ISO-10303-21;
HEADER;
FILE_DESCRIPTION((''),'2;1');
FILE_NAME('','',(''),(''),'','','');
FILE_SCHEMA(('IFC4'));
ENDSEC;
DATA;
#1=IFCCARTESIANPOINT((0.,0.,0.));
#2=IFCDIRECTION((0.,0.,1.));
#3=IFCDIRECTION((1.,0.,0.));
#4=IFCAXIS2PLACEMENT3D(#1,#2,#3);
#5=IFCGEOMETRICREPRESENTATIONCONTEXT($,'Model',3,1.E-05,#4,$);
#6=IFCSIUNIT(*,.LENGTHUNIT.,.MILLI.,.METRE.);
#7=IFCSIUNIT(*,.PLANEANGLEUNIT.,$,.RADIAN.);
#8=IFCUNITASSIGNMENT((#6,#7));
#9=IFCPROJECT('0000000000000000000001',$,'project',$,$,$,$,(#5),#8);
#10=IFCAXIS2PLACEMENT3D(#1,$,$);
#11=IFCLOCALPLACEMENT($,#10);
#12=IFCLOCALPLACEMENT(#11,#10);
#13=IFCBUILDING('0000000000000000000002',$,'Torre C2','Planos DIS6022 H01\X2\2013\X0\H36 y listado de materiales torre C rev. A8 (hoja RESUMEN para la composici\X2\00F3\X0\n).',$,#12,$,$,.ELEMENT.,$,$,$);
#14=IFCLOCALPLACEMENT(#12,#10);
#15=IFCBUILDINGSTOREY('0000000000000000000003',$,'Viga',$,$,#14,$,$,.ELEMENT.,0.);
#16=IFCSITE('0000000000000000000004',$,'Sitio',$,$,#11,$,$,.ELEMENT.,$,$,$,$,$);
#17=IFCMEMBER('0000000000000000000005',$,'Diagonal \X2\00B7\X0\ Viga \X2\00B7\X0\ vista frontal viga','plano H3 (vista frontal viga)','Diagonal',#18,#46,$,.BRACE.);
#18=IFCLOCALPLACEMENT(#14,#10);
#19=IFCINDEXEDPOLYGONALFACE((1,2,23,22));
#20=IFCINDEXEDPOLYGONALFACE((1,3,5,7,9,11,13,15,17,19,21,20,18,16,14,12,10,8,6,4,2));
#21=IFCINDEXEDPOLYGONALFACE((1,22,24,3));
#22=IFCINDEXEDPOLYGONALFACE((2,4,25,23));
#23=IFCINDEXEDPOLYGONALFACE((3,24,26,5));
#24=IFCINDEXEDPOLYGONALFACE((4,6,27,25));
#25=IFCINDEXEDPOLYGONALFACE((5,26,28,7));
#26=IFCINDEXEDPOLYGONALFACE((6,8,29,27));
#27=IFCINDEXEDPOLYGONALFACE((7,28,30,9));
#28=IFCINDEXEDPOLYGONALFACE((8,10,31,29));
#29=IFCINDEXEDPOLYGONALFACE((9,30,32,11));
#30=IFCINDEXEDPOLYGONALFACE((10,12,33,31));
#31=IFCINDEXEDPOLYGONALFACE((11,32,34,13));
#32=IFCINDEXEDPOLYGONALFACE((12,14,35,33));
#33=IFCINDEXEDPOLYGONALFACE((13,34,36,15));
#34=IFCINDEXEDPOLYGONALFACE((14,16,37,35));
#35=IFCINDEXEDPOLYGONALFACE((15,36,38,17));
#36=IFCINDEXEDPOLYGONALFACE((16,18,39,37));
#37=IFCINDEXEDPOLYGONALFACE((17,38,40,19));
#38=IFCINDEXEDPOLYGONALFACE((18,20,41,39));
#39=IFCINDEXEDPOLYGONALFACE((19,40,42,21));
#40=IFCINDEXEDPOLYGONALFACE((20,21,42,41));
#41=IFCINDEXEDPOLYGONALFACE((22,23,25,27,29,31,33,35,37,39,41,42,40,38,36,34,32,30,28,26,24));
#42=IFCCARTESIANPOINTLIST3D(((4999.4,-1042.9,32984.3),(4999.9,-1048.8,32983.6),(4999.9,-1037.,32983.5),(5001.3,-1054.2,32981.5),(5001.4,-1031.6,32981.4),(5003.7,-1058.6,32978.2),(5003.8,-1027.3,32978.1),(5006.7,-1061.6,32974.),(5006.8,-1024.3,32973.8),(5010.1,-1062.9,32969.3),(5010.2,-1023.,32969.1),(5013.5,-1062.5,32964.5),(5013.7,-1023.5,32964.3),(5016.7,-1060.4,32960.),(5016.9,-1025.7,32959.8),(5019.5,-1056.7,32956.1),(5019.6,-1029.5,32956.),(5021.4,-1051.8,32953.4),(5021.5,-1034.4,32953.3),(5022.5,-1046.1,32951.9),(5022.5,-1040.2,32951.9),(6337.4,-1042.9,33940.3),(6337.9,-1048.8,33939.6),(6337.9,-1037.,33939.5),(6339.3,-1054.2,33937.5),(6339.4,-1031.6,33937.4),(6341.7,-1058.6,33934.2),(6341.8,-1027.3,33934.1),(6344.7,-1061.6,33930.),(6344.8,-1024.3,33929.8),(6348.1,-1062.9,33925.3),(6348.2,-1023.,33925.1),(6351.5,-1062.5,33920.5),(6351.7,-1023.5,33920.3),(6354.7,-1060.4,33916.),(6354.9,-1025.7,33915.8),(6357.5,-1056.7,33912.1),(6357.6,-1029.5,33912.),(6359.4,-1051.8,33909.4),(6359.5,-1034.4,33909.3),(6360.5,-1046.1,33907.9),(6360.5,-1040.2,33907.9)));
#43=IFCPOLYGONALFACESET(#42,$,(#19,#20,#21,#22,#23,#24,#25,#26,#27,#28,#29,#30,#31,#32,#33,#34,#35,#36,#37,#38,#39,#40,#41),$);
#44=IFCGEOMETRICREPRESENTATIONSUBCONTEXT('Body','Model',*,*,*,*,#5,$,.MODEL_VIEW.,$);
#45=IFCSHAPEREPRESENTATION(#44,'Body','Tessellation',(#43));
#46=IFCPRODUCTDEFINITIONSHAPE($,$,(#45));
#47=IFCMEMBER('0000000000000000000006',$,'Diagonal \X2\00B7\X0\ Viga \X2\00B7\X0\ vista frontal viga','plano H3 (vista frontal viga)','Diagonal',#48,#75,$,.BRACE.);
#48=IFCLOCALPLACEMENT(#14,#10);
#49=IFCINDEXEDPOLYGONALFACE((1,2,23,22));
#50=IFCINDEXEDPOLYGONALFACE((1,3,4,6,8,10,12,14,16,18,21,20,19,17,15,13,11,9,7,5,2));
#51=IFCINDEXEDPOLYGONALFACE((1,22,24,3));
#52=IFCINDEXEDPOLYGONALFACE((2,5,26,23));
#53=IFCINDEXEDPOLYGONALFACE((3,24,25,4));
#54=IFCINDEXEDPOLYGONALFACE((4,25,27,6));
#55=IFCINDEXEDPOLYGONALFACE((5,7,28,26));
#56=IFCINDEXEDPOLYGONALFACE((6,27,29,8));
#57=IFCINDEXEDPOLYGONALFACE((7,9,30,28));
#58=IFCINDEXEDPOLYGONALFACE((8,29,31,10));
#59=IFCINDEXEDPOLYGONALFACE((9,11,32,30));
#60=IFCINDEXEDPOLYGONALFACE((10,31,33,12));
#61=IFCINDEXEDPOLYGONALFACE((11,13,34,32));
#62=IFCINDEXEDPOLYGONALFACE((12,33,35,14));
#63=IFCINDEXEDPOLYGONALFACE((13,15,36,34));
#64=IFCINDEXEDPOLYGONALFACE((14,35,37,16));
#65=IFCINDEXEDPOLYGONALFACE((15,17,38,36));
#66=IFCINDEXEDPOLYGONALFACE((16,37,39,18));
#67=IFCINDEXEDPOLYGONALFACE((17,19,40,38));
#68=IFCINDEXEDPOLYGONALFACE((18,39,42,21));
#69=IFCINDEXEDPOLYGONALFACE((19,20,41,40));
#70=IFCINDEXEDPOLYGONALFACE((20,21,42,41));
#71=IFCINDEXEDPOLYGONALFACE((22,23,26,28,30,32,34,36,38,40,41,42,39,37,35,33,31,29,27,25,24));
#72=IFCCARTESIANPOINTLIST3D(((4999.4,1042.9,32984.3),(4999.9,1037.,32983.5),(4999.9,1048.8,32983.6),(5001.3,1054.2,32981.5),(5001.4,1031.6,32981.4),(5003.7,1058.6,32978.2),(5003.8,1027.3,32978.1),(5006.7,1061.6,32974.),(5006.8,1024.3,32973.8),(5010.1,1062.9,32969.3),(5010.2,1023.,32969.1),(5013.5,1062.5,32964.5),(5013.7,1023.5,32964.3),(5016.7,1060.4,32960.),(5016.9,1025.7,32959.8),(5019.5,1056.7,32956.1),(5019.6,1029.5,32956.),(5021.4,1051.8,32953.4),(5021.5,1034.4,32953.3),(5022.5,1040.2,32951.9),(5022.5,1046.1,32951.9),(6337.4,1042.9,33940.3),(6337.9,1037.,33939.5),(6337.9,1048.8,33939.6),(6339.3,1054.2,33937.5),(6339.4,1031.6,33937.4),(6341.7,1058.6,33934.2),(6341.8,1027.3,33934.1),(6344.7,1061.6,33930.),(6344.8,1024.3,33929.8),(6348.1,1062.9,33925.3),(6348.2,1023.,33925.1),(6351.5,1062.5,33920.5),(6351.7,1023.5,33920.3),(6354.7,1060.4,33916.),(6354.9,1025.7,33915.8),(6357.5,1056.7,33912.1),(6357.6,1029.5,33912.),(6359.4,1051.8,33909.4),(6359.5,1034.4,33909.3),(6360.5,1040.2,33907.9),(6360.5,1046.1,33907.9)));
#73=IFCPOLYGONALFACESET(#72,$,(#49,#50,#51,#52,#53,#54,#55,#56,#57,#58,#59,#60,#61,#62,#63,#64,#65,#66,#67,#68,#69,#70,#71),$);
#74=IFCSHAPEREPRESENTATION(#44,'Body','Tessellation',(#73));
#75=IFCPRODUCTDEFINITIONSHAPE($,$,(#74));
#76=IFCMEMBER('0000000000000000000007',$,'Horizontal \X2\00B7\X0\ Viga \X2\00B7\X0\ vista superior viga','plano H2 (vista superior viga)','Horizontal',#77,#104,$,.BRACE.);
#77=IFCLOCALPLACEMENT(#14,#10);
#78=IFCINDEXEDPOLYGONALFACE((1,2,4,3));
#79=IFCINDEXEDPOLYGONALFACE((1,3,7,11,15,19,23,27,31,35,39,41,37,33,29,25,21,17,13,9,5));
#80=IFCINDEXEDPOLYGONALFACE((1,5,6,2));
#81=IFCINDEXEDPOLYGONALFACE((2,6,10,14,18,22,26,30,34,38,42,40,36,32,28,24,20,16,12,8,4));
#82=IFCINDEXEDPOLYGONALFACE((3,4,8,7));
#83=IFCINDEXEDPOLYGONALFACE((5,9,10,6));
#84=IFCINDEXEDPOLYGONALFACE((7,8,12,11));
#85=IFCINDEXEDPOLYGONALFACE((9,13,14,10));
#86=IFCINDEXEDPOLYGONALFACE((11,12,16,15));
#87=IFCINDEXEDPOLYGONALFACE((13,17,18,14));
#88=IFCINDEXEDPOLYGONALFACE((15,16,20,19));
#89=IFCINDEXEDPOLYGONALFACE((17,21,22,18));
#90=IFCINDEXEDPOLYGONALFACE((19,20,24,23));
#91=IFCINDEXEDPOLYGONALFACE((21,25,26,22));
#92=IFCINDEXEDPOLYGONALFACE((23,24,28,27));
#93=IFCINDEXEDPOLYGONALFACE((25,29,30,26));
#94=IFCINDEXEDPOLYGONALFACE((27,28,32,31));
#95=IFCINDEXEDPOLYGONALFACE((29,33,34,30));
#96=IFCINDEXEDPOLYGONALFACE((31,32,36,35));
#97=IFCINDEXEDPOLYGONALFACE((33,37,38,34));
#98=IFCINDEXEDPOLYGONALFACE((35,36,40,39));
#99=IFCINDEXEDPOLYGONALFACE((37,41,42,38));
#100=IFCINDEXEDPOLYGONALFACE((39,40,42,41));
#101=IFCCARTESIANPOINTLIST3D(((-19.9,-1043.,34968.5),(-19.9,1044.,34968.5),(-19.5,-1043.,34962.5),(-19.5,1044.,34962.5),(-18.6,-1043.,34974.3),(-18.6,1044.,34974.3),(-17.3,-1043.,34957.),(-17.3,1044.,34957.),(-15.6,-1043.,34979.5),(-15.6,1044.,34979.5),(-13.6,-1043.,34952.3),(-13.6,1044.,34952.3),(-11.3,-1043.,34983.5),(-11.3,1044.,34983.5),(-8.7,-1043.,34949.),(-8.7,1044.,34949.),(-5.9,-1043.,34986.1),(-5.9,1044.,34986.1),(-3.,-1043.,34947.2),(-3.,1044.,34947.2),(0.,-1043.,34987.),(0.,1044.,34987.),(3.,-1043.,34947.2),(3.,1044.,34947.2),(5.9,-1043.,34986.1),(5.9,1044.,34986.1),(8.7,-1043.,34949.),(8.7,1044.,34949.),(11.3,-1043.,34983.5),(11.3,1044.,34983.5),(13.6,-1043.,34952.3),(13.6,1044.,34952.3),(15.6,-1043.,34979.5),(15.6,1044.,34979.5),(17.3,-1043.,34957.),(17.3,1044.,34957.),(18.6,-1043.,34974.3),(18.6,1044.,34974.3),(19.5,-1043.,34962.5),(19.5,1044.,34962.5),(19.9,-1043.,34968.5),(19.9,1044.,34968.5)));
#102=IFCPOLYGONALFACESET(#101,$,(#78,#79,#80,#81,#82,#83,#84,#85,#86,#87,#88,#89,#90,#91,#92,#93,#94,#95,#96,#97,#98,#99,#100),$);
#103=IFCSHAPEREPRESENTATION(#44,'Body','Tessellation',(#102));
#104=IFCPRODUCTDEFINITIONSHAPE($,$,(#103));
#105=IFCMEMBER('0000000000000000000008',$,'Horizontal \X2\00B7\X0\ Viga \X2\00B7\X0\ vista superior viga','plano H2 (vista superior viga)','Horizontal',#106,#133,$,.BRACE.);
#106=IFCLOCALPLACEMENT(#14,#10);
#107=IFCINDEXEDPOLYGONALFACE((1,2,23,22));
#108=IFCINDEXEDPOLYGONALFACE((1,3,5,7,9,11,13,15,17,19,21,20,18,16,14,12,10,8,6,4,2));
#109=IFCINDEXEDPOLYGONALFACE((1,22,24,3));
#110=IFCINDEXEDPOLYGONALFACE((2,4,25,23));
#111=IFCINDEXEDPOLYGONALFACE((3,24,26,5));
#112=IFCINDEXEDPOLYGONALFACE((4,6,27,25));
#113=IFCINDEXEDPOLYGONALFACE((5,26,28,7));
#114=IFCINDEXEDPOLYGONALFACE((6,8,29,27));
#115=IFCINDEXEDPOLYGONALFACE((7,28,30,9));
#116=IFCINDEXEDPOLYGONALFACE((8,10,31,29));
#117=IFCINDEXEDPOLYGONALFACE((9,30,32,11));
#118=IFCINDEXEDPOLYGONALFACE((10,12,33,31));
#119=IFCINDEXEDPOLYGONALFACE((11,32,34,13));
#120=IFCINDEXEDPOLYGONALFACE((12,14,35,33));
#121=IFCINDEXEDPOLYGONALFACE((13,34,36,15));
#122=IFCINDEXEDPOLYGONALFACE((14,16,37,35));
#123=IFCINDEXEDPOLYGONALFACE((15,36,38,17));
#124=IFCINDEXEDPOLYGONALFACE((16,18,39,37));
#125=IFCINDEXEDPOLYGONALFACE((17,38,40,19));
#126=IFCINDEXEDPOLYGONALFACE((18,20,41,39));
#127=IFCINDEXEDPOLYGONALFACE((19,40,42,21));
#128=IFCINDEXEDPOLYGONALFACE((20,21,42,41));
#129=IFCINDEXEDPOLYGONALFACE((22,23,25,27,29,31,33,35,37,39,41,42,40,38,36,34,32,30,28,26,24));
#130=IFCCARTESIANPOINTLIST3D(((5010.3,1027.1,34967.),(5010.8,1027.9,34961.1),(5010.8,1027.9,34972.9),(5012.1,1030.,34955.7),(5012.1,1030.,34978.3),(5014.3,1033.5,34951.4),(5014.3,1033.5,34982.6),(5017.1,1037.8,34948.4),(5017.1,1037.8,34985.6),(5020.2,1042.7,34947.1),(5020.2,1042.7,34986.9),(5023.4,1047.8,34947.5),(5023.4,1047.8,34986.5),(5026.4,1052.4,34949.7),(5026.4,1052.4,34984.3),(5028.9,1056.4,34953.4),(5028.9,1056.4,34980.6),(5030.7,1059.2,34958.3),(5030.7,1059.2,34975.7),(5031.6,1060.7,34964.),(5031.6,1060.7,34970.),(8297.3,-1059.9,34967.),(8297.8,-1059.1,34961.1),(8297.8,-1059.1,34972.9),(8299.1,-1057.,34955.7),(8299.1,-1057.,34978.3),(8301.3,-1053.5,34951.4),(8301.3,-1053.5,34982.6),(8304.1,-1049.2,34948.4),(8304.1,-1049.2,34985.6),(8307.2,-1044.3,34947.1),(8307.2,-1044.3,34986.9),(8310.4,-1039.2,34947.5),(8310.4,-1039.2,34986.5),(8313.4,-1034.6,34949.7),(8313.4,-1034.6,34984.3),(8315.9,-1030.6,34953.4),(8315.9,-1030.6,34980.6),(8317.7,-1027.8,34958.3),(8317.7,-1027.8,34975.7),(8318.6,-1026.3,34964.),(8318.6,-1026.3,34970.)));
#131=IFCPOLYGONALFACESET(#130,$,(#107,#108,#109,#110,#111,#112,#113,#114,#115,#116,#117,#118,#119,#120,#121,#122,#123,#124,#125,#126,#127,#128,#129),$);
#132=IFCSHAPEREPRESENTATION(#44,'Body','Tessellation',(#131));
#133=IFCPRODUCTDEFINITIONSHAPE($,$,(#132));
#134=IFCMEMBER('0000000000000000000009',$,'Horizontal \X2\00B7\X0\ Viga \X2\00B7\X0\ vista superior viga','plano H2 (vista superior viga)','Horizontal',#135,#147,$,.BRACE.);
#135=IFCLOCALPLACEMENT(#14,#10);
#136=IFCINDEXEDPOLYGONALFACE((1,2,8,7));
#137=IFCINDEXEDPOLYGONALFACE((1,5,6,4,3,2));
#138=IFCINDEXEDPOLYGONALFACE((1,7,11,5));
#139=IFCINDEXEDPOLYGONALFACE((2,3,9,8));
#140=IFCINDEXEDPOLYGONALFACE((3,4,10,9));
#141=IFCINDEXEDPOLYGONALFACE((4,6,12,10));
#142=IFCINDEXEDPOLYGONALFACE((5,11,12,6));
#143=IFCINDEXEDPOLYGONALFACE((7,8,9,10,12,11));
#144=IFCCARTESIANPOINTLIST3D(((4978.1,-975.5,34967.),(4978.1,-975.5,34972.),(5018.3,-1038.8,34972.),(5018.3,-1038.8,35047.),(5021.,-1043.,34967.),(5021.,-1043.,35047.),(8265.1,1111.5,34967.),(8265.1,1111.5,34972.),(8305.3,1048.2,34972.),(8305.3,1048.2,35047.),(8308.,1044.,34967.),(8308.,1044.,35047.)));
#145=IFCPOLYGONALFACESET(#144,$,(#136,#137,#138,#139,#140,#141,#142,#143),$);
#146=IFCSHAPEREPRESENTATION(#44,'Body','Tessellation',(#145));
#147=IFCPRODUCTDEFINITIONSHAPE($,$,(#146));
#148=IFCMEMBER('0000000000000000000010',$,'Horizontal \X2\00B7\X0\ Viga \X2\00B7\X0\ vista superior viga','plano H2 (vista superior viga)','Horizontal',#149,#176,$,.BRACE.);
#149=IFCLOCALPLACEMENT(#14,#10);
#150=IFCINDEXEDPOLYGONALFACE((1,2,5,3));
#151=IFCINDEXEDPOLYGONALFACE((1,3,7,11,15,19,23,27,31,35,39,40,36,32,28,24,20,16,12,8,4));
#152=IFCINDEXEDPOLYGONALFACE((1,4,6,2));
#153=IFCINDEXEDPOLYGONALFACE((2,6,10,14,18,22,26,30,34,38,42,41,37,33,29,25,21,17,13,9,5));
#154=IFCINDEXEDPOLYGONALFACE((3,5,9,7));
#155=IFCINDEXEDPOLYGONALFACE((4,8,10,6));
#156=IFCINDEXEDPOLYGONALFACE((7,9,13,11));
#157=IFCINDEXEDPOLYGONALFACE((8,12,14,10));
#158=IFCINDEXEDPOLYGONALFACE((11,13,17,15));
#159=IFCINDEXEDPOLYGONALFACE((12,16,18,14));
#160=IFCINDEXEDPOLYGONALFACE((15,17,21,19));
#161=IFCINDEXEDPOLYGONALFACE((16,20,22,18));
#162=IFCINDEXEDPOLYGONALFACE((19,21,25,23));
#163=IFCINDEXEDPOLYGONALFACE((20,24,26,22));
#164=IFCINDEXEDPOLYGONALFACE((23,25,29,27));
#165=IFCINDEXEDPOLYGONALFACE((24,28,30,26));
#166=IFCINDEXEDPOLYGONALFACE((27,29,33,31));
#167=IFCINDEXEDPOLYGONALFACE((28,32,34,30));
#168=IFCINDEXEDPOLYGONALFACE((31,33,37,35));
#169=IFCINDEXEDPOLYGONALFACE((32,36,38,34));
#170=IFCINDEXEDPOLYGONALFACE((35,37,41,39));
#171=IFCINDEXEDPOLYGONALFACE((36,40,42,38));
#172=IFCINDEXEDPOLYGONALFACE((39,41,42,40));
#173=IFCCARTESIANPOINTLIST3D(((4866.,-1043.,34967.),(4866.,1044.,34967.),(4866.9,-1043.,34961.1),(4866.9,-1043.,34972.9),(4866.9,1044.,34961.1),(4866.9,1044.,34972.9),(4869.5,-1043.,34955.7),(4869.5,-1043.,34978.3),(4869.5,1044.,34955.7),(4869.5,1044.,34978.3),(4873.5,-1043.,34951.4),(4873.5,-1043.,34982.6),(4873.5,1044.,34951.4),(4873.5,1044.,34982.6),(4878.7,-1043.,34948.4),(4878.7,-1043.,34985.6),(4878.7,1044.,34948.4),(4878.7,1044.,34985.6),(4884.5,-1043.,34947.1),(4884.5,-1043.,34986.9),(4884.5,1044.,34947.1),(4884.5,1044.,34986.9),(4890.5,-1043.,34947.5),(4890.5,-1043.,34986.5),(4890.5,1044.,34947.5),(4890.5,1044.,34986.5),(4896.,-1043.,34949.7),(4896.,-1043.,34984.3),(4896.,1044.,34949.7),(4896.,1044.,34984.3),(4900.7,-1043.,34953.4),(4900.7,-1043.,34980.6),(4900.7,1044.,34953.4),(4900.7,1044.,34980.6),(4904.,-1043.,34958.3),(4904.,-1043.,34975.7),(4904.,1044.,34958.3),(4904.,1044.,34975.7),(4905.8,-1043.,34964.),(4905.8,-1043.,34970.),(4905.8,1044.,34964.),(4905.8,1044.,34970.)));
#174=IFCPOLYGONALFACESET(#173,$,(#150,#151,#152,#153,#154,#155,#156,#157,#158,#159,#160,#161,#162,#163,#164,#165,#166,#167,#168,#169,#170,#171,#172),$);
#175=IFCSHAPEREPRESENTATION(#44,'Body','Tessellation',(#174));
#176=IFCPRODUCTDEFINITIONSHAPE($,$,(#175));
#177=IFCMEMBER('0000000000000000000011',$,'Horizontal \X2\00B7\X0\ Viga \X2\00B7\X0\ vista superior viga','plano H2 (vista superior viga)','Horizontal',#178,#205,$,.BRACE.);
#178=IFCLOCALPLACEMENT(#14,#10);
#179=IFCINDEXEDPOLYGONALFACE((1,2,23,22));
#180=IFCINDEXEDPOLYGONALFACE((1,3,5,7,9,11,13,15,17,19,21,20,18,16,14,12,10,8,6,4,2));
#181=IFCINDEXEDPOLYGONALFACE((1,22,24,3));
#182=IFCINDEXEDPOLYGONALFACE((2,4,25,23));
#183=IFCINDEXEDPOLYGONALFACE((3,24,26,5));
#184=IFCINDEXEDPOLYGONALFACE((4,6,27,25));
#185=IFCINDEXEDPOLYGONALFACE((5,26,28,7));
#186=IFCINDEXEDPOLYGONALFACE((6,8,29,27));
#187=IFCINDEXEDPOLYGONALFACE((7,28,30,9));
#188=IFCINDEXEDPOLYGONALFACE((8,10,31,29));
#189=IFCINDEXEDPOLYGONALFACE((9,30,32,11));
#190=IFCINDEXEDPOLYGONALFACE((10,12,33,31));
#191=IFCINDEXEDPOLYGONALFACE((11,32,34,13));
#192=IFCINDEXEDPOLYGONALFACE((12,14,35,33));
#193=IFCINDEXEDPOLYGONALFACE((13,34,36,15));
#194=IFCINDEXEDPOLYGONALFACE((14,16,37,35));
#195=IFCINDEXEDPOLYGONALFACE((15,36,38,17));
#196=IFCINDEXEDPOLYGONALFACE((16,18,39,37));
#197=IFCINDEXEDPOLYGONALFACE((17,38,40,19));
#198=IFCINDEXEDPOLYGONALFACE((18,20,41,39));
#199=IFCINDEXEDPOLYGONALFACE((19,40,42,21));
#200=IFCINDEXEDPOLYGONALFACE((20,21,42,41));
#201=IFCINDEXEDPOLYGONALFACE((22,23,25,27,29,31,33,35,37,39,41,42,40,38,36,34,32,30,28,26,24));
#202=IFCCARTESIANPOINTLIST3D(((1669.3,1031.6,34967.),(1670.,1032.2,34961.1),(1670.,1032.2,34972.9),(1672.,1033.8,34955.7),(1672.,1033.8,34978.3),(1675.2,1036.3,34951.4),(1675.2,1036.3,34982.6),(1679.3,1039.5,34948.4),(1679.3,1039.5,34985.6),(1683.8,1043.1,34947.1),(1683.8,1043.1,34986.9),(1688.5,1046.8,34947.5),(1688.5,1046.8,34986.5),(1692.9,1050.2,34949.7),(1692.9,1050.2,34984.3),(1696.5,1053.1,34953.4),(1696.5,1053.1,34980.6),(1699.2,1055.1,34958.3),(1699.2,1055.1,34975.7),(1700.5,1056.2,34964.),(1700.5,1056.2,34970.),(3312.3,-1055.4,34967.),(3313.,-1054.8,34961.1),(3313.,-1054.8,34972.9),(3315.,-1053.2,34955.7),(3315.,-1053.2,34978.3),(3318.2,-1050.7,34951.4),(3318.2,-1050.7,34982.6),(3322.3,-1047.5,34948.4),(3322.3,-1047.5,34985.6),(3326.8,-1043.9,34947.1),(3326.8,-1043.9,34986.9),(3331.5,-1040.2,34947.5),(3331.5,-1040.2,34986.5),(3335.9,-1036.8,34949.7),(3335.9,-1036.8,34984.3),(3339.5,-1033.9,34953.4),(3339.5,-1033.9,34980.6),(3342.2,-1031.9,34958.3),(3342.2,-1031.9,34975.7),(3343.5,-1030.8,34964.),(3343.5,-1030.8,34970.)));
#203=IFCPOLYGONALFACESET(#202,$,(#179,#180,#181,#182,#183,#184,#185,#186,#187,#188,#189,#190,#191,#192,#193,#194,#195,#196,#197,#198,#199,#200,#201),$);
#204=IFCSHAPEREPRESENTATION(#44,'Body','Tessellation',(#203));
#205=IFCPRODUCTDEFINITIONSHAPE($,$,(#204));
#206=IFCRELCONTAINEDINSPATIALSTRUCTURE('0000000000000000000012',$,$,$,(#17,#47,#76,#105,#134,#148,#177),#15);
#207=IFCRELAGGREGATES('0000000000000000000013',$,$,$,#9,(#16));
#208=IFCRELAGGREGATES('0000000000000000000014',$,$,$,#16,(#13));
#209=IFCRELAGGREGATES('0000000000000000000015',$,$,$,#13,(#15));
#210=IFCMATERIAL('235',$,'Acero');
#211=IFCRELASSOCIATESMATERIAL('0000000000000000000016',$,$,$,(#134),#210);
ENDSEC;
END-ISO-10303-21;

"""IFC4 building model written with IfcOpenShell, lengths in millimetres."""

from ifc_helpers import new_model, si_unit, frame, frame_2d, origin, origin_with_axes, place, context, subcontext, project, spatial, circle, l_section, extrude, material, element, save


model = new_model("IFC4")

# Units and contexts
model_context = context("Model", 3, precision=1e-05, world=origin_with_axes())
body_context = subcontext(model_context, "Body", "Model", "MODEL_VIEW")
ifc_project = project(units=[si_unit("LENGTHUNIT", "METRE", prefix="MILLI"), si_unit("PLANEANGLEUNIT", "RADIAN")], contexts=[model_context])

# Site, building, storey
site_placement = place(None, origin())
site = spatial("IfcSite", under=ifc_project, at=site_placement, Name="Sitio", CompositionType="ELEMENT")
building_placement = place(site_placement, origin())
building = spatial("IfcBuilding", under=site, at=building_placement, Name="Torre C2", Description="Planos DIS6022 H01–H36 y listado de materiales torre C rev. A8 (hoja RESUMEN para la composición).", CompositionType="ELEMENT")
storey_placement = place(building_placement, origin())
storey = spatial("IfcBuildingStorey", under=building, at=storey_placement, Name="Viga", CompositionType="ELEMENT", Elevation=0.0)

# Members
for number, where, z_axis, x_axis, name in (
    (1, (5011.0, -1043.0, 32968.0), (0.813651, 0.0, 0.581353), (-0.554357, 0.301193, 0.775868), "Diagonal · Viga · vista frontal viga"),
    (2, (5011.0, 1043.0, 32968.0), (0.813651, 0.0, 0.581353), (-0.554357, -0.301193, 0.775868), "Diagonal · Viga · vista frontal viga"),
):
    element("IfcMember", number, at=place(storey_placement, frame(where, z_axis=z_axis, x_axis=x_axis)), inside=storey, Name=name, Description="plano H3 (vista frontal viga)", ObjectType="Diagonal", PredefinedType="BRACE", context=body_context, shape_type="SweptSolid", body=[
        extrude(circle(Radius=20.0), None, (0.0, 0.0, 1.0), 1644.4),
    ])
member_1_placement = place(storey_placement, frame((0.0, 1044.0, 34967.0), z_axis=(0.0, -1.0, 0.0), x_axis=(0.0, 0.0, 1.0)))
element("IfcMember", 3, at=member_1_placement, inside=storey, Name="Horizontal · Viga · vista superior viga", Description="plano H2 (vista superior viga)", ObjectType="Horizontal", PredefinedType="BRACE", context=body_context, shape_type="SweptSolid", body=[
    extrude(circle(Radius=20.0), None, (0.0, 0.0, 1.0), 2087.0),
])
member_2_placement = place(storey_placement, frame((5021.0, 1044.0, 34967.0), z_axis=(0.844211, -0.536011, 0.0), x_axis=(-0.536011, -0.844211, 0.0)))
element("IfcMember", 4, at=member_2_placement, inside=storey, Name="Horizontal · Viga · vista superior viga", Description="plano H2 (vista superior viga)", ObjectType="Horizontal", PredefinedType="BRACE", context=body_context, shape_type="SweptSolid", body=[
    extrude(circle(Radius=20.0), None, (0.0, 0.0, 1.0), 3893.6),
])
ifc_material_1 = material(Name="235", Category="Acero")
member_3_placement = place(storey_placement, frame((5021.0, -1043.0, 34967.0), z_axis=(0.844211, 0.536011, 0.0), x_axis=(-0.536011, 0.844211, 0.0)))
element("IfcMember", 5, at=member_3_placement, inside=storey, material=ifc_material_1, Name="Horizontal · Viga · vista superior viga", Description="plano H2 (vista superior viga)", ObjectType="Horizontal", PredefinedType="BRACE", context=body_context, shape_type="SweptSolid", body=[
    extrude(l_section(Depth=80.0, Width=80.0, Thickness=5.0, at=frame_2d((40.0, 40.0))), None, (0.0, 0.0, 1.0), 3893.6),
])
member_4_placement = place(storey_placement, frame((4886.0, 1044.0, 34967.0), z_axis=(0.0, -1.0, 0.0), x_axis=(-1.0, 0.0, 0.0)))
element("IfcMember", 6, at=member_4_placement, inside=storey, Name="Horizontal · Viga · vista superior viga", Description="plano H2 (vista superior viga)", ObjectType="Horizontal", PredefinedType="BRACE", context=body_context, shape_type="SweptSolid", body=[
    extrude(circle(Radius=20.0), None, (0.0, 0.0, 1.0), 2087.0),
])
member_5_placement = place(storey_placement, frame((1685.0, 1044.0, 34967.0), z_axis=(0.618569, -0.78573, 0.0), x_axis=(-0.78573, -0.618569, 0.0)))
element("IfcMember", 7, at=member_5_placement, inside=storey, Name="Horizontal · Viga · vista superior viga", Description="plano H2 (vista superior viga)", ObjectType="Horizontal", PredefinedType="BRACE", context=body_context, shape_type="SweptSolid", body=[
    extrude(circle(Radius=20.0), None, (0.0, 0.0, 1.0), 2656.1),
])

save(model, "model.ifc")
